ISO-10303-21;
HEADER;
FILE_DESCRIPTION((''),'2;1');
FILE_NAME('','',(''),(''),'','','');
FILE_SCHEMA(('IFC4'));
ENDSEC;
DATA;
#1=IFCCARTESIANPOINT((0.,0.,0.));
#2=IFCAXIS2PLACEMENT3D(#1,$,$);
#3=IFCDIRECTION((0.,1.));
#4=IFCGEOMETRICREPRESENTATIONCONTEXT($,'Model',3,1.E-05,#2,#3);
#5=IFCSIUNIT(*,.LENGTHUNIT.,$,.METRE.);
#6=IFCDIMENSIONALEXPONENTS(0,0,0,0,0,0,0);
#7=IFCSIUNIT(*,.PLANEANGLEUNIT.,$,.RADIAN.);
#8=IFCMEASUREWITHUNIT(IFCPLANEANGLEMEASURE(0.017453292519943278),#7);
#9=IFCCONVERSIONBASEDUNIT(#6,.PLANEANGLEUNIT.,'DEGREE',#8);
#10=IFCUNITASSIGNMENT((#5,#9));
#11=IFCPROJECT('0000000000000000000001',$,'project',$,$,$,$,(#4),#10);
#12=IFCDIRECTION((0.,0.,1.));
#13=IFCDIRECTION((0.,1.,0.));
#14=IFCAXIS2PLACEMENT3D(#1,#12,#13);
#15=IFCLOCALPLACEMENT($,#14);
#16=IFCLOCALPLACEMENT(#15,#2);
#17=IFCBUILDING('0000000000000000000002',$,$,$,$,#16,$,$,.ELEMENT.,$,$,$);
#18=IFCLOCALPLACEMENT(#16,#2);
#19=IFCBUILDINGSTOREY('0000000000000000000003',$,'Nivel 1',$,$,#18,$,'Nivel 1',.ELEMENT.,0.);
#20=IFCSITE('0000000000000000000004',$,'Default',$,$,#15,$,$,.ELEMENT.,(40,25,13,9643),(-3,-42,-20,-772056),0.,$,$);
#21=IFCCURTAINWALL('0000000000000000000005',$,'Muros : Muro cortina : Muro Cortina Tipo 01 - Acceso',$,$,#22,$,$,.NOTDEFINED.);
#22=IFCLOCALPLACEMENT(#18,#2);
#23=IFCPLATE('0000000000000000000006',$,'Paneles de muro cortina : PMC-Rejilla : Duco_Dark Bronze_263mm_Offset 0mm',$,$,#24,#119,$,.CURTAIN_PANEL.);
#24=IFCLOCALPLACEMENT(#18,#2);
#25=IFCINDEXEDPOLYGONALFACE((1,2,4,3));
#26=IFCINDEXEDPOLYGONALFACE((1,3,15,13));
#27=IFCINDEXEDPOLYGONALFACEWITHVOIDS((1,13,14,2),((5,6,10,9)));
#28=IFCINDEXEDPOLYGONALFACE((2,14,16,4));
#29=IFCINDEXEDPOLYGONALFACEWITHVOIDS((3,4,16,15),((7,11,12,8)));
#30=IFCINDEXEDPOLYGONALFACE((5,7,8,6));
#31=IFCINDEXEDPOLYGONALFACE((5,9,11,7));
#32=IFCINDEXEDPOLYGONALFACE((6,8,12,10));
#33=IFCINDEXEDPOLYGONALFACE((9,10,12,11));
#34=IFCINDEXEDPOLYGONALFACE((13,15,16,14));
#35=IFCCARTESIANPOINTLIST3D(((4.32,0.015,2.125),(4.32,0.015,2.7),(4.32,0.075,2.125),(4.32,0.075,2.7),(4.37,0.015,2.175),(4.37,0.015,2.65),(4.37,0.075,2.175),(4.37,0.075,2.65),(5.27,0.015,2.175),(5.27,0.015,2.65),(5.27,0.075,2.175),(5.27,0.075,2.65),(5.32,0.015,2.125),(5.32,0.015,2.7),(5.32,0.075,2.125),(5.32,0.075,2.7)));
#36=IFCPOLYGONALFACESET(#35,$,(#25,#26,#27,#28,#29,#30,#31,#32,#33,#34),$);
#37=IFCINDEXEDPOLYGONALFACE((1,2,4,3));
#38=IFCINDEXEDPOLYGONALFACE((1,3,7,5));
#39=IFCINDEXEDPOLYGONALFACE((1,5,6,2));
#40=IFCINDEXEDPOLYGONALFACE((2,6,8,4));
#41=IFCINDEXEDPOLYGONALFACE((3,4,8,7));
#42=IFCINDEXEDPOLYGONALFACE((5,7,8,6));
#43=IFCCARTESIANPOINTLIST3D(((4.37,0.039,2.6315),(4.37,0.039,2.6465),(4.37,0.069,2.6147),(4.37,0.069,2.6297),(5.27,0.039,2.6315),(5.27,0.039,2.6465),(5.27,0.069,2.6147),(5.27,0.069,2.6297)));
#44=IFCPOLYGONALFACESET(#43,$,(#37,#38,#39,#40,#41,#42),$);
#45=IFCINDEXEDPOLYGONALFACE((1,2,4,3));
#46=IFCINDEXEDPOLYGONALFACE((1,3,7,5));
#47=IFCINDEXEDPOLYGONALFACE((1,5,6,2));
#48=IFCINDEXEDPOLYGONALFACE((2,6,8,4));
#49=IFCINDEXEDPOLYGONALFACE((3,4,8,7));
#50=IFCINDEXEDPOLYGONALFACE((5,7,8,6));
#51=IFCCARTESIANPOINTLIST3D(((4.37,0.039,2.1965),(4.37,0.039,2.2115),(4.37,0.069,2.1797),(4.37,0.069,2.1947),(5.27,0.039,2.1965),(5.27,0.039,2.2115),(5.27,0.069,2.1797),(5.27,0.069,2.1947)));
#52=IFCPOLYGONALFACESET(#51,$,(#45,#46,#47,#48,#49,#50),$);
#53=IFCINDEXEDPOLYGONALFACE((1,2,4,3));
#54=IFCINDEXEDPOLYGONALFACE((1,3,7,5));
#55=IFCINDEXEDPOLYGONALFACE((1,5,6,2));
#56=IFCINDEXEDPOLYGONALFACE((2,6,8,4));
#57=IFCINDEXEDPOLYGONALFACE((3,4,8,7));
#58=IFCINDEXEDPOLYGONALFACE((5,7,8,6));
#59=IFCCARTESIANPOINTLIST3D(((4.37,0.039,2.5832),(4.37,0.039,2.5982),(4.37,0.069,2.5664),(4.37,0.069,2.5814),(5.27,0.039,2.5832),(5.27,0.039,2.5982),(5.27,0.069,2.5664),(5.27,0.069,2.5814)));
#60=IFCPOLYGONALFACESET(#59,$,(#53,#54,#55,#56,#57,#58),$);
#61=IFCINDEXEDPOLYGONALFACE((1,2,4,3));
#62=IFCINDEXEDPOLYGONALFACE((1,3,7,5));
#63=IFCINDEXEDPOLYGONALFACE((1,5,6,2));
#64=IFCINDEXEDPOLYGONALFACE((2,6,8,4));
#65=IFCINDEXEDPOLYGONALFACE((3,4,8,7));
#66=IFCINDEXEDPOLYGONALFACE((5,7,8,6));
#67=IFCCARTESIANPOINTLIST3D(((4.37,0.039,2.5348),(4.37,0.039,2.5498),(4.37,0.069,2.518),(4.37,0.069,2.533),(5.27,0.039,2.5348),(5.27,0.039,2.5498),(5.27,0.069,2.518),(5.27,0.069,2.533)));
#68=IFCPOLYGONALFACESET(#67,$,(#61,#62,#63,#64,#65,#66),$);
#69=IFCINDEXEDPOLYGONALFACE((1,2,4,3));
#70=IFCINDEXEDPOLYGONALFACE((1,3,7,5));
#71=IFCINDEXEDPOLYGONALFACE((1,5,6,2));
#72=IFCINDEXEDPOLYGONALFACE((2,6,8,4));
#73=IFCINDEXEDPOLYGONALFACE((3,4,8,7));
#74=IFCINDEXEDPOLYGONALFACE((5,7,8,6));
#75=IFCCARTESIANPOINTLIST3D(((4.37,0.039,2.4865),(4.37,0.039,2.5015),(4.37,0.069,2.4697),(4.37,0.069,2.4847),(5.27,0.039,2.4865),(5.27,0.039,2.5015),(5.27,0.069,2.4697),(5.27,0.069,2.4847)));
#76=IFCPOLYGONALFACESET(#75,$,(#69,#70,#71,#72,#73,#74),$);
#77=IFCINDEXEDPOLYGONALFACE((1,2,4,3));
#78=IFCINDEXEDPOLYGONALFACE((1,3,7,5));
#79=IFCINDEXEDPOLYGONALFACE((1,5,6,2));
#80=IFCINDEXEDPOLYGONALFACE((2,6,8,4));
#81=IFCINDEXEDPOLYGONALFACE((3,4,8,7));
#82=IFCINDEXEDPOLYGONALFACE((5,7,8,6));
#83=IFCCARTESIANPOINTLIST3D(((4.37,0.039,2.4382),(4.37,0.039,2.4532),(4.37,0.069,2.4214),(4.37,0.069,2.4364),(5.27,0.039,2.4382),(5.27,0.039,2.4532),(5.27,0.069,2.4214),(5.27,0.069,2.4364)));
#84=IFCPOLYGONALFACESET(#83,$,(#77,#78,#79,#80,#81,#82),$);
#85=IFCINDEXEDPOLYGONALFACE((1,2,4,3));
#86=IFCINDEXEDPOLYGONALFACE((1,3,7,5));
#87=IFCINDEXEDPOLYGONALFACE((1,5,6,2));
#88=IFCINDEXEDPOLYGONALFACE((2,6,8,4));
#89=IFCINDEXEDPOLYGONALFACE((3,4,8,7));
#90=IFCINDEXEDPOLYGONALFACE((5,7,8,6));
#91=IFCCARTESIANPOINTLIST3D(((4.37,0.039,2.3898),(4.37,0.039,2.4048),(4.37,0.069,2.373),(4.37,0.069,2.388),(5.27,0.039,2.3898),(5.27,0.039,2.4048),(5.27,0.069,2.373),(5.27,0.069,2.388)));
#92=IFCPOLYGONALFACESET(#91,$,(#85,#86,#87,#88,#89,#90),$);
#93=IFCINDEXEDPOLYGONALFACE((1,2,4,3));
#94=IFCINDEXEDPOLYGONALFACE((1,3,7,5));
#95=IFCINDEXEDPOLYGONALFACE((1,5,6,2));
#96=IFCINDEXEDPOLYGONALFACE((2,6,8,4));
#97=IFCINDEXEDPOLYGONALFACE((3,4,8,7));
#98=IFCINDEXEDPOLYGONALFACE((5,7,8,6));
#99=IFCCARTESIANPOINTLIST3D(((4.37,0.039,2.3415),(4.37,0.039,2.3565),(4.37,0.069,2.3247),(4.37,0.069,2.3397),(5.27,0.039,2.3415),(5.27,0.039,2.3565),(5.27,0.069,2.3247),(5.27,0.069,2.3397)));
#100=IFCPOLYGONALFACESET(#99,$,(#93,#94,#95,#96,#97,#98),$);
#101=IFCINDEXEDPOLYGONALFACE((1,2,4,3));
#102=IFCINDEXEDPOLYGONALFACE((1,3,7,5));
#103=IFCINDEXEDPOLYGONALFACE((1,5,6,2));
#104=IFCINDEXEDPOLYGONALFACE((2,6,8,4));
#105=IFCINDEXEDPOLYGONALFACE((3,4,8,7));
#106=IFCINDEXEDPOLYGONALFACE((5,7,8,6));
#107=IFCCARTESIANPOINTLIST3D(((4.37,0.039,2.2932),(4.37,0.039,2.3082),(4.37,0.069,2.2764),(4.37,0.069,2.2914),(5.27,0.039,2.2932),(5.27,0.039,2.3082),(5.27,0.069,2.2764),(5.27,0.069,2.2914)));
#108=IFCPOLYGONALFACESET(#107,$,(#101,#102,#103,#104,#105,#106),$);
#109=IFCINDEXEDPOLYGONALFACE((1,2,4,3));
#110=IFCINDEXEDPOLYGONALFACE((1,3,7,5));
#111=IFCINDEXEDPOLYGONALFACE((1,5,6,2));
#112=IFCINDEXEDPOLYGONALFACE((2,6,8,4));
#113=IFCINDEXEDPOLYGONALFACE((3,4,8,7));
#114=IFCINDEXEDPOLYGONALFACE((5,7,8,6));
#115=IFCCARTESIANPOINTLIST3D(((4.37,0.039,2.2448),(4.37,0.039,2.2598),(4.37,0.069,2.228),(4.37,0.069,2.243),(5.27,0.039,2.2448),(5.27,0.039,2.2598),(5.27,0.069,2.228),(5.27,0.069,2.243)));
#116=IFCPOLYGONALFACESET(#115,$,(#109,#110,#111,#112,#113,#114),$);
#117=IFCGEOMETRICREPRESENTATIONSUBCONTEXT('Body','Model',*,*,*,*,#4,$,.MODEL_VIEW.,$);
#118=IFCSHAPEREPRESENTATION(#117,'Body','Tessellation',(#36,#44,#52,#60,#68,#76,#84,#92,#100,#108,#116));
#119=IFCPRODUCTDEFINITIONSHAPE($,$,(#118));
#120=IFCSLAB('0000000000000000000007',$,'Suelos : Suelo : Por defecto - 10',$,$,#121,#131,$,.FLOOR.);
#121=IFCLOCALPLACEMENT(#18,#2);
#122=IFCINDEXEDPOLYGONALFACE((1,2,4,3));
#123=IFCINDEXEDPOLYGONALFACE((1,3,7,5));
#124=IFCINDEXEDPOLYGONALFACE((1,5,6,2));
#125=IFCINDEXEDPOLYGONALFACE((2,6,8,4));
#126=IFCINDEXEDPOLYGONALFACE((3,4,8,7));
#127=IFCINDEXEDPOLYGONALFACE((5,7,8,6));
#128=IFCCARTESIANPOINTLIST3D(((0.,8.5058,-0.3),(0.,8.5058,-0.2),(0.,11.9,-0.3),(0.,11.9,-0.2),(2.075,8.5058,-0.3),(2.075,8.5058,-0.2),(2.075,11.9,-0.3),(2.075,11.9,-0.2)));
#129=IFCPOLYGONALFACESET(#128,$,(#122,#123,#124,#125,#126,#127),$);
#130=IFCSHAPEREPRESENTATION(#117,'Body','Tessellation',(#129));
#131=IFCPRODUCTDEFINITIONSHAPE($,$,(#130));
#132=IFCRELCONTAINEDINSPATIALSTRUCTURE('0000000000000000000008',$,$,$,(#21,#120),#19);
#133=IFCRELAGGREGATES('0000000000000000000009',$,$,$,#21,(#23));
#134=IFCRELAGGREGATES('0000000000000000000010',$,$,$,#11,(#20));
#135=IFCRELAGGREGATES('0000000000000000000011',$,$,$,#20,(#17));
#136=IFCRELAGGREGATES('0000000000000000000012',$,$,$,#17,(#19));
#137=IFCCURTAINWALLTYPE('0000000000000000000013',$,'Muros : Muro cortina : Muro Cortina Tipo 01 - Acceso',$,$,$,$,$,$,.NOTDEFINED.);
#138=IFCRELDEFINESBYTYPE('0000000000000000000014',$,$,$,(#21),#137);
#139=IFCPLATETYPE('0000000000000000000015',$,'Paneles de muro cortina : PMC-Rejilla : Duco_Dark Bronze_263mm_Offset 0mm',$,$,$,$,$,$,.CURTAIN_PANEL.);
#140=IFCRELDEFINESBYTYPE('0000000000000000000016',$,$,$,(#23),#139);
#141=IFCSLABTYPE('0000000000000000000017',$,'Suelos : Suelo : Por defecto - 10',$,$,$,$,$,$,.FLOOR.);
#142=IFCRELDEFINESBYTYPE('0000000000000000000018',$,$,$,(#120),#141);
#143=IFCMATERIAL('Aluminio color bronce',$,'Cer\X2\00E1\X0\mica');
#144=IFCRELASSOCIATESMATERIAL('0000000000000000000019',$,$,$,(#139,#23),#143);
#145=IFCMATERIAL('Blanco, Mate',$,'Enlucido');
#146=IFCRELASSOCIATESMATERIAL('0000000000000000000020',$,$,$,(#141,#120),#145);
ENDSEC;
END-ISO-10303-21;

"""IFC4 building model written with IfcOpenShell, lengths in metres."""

from ifc_helpers import new_model, entity, si_unit, converted_unit, direction, frame, origin, place, context, subcontext, project, spatial, indexed_curve, outline, extrude, source, transform, mapped, material, type_object, type_shapes, element, aggregate, save


model = new_model("IFC4")

# Units and contexts
model_context = context("Model", 3, precision=1e-05, world=origin(), true_north=direction((0.0, 1.0)))
body_context = subcontext(model_context, "Body", "Model", "MODEL_VIEW")
ifc_project = project(units=[si_unit("LENGTHUNIT", "METRE"), converted_unit("PLANEANGLEUNIT", "DEGREE", entity("IfcPlaneAngleMeasure", 0.017453292519943278), si_unit("PLANEANGLEUNIT", "RADIAN"), dimensions=[0, 0, 0, 0, 0, 0, 0])], contexts=[model_context])

# Site, building, storey
site_placement = place(None, frame((0.0, 0.0, 0.0), z_axis=(0.0, 0.0, 1.0), x_axis=(0.0, 1.0, 0.0)))
site = spatial("IfcSite", under=ifc_project, at=site_placement, Name="Default", CompositionType="ELEMENT", RefLatitude=(40, 25, 13, 9643), RefLongitude=(-3, -42, -20, -772056), RefElevation=0.0)
building_placement = place(site_placement, origin())
building = spatial("IfcBuilding", under=site, at=building_placement, CompositionType="ELEMENT")
storey_placement = place(building_placement, origin())
storey = spatial("IfcBuildingStorey", under=building, at=storey_placement, Name="Nivel 1", LongName="Nivel 1", CompositionType="ELEMENT", Elevation=0.0)

# Shared definitions
ifc_material_1 = material(Name="Blanco, Mate", Category="Enlucido")

# Curtain wall, plate
curtain_wall_type_1 = type_object("IfcCurtainWallType", Name="Muros : Muro cortina : Muro Cortina Tipo 01 - Acceso", PredefinedType="NOTDEFINED")
curtain_wall_1_placement = place(storey_placement, origin())
curtain_wall_1 = element("IfcCurtainWall", 1, at=curtain_wall_1_placement, inside=storey, type_object=curtain_wall_type_1, Name="Muros : Muro cortina : Muro Cortina Tipo 01 - Acceso", PredefinedType="NOTDEFINED")
ifc_material_2 = material(Name="Aluminio color bronce", Category="Cerámica")
plate_type = type_object("IfcPlateType", Name="Paneles de muro cortina : PMC-Rejilla : Duco_Dark Bronze_263mm_Offset 0mm", PredefinedType="CURTAIN_PANEL", material=ifc_material_2)
shared_shape_1 = source(origin(), body_context, "Body", "SweptSolid", [
    extrude(outline(indexed_curve([(-0.2875, -0.5), (0.2875, -0.5), (0.2875, 0.5), (-0.2875, 0.5), (-0.2875, -0.5)], self_intersect=False), holes=[indexed_curve([(-0.2375, -0.45), (-0.2375, 0.45), (0.2375, 0.45), (0.2375, -0.45), (-0.2375, -0.45)], self_intersect=False)]), frame((0.0, -0.06, 0.2875), z_axis=(0.0, 1.0, 0.0), x_axis=(0.0, 0.0, -1.0)), (0.0, 0.0, 1.0), 0.06),
    extrude(outline(indexed_curve([(-0.0159, -0.015), (-0.0009, -0.015), (0.0159, 0.015), (0.0009, 0.015), (-0.0159, -0.015)], self_intersect=False)), frame((-0.45, -0.021, 0.5056), z_axis=(1.0, 0.0, 0.0), x_axis=(0.0, 0.0, -1.0)), (0.0, 0.0, 1.0), 0.9),
    extrude(outline(indexed_curve([(-0.0159, -0.015), (-0.0009, -0.015), (0.0159, 0.015), (0.0009, 0.015), (-0.0159, -0.015)], self_intersect=False)), frame((-0.45, -0.021, 0.0706), z_axis=(1.0, 0.0, 0.0), x_axis=(0.0, 0.0, -1.0)), (0.0, 0.0, 1.0), 0.9),
    extrude(outline(indexed_curve([(-0.0159, -0.015), (-0.0009, -0.015), (0.0159, 0.015), (0.0009, 0.015), (-0.0159, -0.015)], self_intersect=False)), frame((-0.45, -0.021, 0.4573), z_axis=(1.0, 0.0, 0.0), x_axis=(0.0, 0.0, -1.0)), (0.0, 0.0, 1.0), 0.9),
    extrude(outline(indexed_curve([(-0.0159, -0.015), (-0.0009, -0.015), (0.0159, 0.015), (0.0009, 0.015), (-0.0159, -0.015)], self_intersect=False)), frame((-0.45, -0.021, 0.4089), z_axis=(1.0, 0.0, 0.0), x_axis=(0.0, 0.0, -1.0)), (0.0, 0.0, 1.0), 0.9),
    extrude(outline(indexed_curve([(-0.0159, -0.015), (-0.0009, -0.015), (0.0159, 0.015), (0.0009, 0.015), (-0.0159, -0.015)], self_intersect=False)), frame((-0.45, -0.021, 0.3606), z_axis=(1.0, 0.0, 0.0), x_axis=(0.0, 0.0, -1.0)), (0.0, 0.0, 1.0), 0.9),
    extrude(outline(indexed_curve([(-0.0159, -0.015), (-0.0009, -0.015), (0.0159, 0.015), (0.0009, 0.015), (-0.0159, -0.015)], self_intersect=False)), frame((-0.45, -0.021, 0.3123), z_axis=(1.0, 0.0, 0.0), x_axis=(0.0, 0.0, -1.0)), (0.0, 0.0, 1.0), 0.9),
    extrude(outline(indexed_curve([(-0.0159, -0.015), (-0.0009, -0.015), (0.0159, 0.015), (0.0009, 0.015), (-0.0159, -0.015)], self_intersect=False)), frame((-0.45, -0.021, 0.2639), z_axis=(1.0, 0.0, 0.0), x_axis=(0.0, 0.0, -1.0)), (0.0, 0.0, 1.0), 0.9),
    extrude(outline(indexed_curve([(-0.0159, -0.015), (-0.0009, -0.015), (0.0159, 0.015), (0.0009, 0.015), (-0.0159, -0.015)], self_intersect=False)), frame((-0.45, -0.021, 0.2156), z_axis=(1.0, 0.0, 0.0), x_axis=(0.0, 0.0, -1.0)), (0.0, 0.0, 1.0), 0.9),
    extrude(outline(indexed_curve([(-0.0159, -0.015), (-0.0009, -0.015), (0.0159, 0.015), (0.0009, 0.015), (-0.0159, -0.015)], self_intersect=False)), frame((-0.45, -0.021, 0.1673), z_axis=(1.0, 0.0, 0.0), x_axis=(0.0, 0.0, -1.0)), (0.0, 0.0, 1.0), 0.9),
    extrude(outline(indexed_curve([(-0.0159, -0.015), (-0.0009, -0.015), (0.0159, 0.015), (0.0009, 0.015), (-0.0159, -0.015)], self_intersect=False)), frame((-0.45, -0.021, 0.1189), z_axis=(1.0, 0.0, 0.0), x_axis=(0.0, 0.0, -1.0)), (0.0, 0.0, 1.0), 0.9),
])
type_shapes(plate_type, [shared_shape_1])
plate_placement = place(curtain_wall_1_placement, frame((4.82, 0.075, 2.125)))
plate = element("IfcPlate", 2, at=plate_placement, type_object=plate_type, material=ifc_material_2, Name="Paneles de muro cortina : PMC-Rejilla : Duco_Dark Bronze_263mm_Offset 0mm", PredefinedType="CURTAIN_PANEL", context=body_context, shape_type="MappedRepresentation", body=[
    mapped(shared_shape_1, transform((0.0, 0.0, 0.0), scale=1.0)),
])
aggregate(curtain_wall_1, [plate])

# Slab
slab_type = type_object("IfcSlabType", Name="Suelos : Suelo : Por defecto - 10", PredefinedType="FLOOR", material=ifc_material_1)
slab_placement = place(storey_placement, origin())
element("IfcSlab", 3, at=slab_placement, inside=storey, type_object=slab_type, material=ifc_material_1, Name="Suelos : Suelo : Por defecto - 10", PredefinedType="FLOOR", context=body_context, shape_type="SweptSolid", body=[
    extrude(outline(indexed_curve([(-1.6971, -1.0375), (1.6971, -1.0375), (1.6971, 1.0375), (-1.6971, 1.0375), (-1.6971, -1.0375)], self_intersect=False)), frame((1.0375, 10.2029, -0.2), z_axis=(0.0, 0.0, -1.0), x_axis=(0.0, 1.0, 0.0)), (0.0, 0.0, 1.0), 0.1),
])

save(model, "model.ifc")
